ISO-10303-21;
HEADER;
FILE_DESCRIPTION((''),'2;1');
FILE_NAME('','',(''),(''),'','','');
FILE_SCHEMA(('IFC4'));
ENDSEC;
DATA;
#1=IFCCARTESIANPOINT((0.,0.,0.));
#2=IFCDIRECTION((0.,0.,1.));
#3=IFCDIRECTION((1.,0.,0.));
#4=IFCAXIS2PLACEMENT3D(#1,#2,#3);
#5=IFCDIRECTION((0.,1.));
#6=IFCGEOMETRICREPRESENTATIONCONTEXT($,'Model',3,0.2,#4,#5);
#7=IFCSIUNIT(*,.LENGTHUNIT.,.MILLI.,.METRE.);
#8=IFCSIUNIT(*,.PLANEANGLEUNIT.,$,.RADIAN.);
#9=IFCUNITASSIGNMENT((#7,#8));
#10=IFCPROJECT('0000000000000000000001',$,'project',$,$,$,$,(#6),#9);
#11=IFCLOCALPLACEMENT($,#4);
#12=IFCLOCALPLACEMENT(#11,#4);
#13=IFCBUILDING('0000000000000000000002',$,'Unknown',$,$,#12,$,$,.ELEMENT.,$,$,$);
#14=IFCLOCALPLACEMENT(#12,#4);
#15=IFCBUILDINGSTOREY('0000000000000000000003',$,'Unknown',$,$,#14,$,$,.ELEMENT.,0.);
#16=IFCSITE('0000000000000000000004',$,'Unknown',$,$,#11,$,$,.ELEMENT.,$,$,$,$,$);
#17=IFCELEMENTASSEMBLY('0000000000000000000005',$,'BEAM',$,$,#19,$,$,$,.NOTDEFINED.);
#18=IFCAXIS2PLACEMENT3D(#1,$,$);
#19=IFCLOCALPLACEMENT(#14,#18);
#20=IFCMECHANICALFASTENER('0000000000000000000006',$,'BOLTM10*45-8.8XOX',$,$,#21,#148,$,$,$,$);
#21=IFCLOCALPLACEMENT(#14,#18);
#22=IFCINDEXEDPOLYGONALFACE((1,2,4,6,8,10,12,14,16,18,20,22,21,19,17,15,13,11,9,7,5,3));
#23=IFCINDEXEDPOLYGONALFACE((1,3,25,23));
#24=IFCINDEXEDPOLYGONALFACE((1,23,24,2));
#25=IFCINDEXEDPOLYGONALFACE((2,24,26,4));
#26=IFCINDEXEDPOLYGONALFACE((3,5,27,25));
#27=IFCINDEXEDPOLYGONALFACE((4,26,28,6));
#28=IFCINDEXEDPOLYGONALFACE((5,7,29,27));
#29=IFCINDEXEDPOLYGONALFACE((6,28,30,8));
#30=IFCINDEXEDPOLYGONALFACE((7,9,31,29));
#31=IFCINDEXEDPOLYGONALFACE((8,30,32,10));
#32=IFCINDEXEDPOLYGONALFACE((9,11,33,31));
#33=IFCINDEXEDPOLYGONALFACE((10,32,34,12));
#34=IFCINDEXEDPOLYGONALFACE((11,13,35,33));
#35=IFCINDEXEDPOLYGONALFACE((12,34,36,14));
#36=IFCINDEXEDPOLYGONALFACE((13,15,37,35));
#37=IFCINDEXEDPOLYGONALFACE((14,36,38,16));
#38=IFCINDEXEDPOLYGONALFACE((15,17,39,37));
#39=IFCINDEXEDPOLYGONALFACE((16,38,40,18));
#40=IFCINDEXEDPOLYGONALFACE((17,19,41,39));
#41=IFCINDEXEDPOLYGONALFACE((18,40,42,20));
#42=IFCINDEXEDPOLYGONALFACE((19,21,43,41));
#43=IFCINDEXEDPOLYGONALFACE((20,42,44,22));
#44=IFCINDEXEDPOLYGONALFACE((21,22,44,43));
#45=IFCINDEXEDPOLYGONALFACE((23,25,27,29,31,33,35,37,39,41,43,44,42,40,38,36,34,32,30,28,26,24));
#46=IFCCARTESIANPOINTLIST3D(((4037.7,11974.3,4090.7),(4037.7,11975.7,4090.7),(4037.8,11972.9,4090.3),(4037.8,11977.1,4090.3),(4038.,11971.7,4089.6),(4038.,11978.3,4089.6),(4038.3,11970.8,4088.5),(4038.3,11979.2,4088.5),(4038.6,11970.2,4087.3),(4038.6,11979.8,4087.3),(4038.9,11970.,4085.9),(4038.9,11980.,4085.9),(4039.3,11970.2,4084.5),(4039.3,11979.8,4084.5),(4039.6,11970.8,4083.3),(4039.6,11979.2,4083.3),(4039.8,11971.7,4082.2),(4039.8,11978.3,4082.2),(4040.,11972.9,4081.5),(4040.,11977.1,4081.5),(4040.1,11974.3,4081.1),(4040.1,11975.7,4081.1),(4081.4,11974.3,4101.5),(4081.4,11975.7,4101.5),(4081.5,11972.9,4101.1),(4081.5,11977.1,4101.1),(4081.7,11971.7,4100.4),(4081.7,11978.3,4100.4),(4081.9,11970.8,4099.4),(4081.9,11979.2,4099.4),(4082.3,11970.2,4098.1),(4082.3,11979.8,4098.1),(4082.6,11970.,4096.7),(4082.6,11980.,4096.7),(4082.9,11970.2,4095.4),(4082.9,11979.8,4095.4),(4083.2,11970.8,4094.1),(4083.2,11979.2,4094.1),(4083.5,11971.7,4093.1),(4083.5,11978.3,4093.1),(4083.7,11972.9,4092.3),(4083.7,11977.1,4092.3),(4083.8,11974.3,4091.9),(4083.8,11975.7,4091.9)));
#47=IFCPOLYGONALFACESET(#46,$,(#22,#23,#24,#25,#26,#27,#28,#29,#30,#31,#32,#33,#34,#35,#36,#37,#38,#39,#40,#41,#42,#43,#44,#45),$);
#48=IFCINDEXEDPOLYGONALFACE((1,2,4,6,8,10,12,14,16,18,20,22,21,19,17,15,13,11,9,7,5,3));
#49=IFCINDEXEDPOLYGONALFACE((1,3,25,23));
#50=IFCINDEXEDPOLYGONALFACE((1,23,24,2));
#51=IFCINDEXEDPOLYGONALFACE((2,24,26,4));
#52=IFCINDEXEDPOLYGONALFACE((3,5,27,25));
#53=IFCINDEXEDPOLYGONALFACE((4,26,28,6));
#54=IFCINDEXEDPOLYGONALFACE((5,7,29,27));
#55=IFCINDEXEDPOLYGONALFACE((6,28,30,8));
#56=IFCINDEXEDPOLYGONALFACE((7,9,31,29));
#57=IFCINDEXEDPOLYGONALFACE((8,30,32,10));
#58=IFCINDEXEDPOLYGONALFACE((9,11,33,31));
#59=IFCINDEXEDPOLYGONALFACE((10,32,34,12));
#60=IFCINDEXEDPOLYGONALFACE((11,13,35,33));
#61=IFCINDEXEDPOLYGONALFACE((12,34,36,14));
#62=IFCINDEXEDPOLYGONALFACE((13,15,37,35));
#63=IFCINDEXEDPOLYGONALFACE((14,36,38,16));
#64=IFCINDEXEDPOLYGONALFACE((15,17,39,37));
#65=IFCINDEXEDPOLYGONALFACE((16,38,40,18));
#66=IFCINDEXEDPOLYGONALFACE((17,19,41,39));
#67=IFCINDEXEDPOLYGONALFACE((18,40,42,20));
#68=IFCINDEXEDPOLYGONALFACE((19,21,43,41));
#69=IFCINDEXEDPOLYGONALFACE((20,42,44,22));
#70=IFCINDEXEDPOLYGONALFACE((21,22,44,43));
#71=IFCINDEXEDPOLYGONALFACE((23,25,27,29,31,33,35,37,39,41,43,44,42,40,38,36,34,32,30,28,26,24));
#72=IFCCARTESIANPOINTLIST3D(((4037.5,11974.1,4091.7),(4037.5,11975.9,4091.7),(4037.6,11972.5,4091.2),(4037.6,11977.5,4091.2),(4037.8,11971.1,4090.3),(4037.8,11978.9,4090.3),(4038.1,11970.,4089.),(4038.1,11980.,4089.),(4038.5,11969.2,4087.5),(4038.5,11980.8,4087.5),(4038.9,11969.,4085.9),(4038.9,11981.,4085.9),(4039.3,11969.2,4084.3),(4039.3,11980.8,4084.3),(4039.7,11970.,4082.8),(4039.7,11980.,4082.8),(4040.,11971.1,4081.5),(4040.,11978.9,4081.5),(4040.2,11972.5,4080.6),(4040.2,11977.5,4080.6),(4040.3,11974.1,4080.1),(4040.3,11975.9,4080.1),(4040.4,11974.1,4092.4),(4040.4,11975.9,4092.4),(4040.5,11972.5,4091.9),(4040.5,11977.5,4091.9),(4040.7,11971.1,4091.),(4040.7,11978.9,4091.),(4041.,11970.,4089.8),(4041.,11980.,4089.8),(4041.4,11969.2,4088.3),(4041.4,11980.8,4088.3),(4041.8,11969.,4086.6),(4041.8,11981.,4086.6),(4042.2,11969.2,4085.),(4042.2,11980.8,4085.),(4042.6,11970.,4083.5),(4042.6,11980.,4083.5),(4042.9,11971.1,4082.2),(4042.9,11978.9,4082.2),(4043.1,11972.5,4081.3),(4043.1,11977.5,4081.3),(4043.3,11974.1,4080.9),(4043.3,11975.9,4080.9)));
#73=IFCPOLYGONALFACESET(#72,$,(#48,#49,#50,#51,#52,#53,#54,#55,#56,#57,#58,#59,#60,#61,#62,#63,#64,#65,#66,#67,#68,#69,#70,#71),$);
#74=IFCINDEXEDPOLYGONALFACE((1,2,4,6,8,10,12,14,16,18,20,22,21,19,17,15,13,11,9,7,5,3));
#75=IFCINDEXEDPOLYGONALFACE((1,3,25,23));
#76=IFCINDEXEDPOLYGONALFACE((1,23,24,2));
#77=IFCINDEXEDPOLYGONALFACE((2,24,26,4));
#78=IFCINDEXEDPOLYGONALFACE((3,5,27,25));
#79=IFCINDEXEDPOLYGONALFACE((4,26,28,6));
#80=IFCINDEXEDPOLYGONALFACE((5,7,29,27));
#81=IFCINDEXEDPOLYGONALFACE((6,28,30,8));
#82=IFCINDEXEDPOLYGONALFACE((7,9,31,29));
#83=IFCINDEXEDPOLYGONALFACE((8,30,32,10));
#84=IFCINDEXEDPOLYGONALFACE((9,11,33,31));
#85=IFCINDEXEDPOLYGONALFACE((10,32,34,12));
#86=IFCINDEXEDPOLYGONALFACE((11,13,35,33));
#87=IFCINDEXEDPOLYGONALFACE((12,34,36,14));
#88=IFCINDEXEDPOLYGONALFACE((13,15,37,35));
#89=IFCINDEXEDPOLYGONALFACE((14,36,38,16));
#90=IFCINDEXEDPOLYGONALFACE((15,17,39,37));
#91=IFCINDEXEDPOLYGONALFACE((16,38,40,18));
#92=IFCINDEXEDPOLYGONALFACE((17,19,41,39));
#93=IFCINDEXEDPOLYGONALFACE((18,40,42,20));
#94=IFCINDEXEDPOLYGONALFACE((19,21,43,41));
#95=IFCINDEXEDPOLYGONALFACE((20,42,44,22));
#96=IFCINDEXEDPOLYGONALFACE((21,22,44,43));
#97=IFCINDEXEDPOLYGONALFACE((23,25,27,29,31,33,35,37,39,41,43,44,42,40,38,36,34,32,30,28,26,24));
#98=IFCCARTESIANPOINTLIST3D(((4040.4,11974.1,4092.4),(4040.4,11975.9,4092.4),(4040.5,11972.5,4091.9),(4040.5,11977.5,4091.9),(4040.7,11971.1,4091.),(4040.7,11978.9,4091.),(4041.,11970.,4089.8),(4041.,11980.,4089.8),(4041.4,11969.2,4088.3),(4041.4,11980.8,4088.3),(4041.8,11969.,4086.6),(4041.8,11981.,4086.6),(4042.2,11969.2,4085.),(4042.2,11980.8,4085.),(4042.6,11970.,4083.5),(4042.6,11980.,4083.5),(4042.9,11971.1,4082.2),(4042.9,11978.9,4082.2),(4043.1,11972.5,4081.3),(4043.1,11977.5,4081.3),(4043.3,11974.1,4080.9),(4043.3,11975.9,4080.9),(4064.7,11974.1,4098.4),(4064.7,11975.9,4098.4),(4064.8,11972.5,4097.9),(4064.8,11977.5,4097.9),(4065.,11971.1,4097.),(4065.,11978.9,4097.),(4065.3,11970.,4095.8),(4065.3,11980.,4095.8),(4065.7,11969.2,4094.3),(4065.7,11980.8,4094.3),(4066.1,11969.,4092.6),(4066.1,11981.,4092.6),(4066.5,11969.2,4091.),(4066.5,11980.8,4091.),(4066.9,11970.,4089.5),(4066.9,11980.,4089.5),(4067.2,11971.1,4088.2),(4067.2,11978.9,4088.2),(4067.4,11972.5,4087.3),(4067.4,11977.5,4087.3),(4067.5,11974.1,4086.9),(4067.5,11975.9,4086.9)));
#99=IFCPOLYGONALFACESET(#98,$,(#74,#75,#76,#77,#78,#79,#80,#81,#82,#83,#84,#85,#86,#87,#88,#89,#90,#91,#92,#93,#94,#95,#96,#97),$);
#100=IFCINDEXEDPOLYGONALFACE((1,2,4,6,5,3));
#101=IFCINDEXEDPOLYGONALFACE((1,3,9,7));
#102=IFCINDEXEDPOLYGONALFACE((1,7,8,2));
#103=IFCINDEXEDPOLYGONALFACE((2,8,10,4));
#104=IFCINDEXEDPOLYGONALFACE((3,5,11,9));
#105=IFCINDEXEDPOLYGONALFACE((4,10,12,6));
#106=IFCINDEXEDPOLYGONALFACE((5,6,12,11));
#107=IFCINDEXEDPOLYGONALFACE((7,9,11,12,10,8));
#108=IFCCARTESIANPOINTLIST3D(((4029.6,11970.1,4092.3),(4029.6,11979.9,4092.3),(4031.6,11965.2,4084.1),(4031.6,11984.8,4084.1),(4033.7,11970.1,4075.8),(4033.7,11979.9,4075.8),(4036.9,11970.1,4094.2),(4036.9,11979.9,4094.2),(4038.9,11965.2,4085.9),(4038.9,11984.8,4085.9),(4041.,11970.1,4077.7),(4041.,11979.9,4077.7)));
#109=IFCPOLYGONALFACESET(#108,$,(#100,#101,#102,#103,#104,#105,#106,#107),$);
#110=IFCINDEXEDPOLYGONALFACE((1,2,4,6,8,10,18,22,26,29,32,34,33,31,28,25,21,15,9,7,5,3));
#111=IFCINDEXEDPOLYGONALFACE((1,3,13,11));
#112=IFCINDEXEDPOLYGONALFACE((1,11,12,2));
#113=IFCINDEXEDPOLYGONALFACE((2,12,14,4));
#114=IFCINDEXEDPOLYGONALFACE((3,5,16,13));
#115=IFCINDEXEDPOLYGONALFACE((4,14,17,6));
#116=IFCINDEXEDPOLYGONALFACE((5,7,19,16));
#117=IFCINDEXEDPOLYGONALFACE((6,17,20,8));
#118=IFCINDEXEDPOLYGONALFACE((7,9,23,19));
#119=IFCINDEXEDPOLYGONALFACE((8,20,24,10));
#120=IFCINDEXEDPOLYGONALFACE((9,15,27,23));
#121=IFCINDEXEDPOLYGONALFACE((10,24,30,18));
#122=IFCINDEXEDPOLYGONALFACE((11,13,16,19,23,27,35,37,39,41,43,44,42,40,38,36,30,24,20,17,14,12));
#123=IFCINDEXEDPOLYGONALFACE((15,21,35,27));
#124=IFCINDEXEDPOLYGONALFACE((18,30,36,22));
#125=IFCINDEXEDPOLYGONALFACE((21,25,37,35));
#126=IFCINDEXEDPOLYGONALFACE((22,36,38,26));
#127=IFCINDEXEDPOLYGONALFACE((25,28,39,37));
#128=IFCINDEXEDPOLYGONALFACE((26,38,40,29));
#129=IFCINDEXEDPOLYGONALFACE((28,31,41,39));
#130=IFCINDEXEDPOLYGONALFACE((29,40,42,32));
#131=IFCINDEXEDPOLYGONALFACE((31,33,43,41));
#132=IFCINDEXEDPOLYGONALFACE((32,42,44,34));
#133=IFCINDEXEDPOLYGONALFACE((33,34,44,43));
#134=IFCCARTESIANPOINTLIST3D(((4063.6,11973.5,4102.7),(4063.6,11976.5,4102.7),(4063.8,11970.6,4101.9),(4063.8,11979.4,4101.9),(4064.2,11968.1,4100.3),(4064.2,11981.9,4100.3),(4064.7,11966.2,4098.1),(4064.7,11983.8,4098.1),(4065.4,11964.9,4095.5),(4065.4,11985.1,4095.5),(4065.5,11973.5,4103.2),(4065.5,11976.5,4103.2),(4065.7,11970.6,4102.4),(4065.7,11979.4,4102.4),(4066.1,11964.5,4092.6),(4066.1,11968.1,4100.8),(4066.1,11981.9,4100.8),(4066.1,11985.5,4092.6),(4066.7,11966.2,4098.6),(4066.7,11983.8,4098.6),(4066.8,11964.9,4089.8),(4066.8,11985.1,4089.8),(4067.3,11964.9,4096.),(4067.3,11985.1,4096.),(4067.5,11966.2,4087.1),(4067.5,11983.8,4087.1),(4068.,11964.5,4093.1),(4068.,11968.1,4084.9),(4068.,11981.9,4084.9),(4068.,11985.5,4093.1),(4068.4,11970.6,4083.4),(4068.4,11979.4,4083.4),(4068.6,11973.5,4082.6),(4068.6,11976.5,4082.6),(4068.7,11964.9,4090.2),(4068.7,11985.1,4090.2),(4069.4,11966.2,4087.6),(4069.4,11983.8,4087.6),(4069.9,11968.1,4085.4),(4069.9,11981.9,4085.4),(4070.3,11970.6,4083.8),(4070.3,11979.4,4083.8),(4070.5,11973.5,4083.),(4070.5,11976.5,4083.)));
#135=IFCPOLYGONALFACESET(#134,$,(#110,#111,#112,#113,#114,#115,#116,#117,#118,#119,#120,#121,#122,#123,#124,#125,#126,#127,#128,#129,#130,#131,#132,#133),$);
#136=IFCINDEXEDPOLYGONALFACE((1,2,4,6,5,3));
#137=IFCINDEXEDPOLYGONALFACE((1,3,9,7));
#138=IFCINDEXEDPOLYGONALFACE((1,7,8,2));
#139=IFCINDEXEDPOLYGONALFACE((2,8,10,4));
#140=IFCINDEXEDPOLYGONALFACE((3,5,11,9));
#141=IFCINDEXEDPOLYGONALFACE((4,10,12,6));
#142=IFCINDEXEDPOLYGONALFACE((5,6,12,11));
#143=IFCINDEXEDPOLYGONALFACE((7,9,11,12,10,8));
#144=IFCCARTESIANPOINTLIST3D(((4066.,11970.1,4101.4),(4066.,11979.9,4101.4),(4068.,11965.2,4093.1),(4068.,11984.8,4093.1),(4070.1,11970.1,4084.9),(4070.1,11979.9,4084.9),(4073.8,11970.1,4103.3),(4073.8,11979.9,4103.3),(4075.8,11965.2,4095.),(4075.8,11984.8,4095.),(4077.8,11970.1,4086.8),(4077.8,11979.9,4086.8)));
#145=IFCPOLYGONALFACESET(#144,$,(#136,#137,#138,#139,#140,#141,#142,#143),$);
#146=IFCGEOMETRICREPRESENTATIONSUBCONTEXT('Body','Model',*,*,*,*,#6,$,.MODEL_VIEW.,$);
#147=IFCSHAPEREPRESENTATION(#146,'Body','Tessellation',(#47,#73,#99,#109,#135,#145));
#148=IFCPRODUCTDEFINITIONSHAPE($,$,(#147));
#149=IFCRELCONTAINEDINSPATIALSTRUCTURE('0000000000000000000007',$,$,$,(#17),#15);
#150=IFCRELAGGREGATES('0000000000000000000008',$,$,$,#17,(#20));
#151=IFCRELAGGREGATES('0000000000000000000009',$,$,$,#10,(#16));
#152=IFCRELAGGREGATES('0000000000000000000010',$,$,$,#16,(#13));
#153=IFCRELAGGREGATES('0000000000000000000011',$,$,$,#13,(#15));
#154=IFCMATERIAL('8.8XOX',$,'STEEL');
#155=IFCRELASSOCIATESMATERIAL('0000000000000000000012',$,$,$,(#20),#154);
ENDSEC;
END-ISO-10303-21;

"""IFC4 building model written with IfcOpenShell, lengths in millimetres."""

from ifc_helpers import new_model, si_unit, direction, frame, origin_with_axes, place, context, subcontext, project, spatial, line, arc, indexed_curve, outline, extrude, source, transform, mapped, material, element, aggregate, save


model = new_model("IFC4")

# Units and contexts
model_context = context("Model", 3, precision=0.2, world=origin_with_axes(), true_north=direction((0.0, 1.0)))
body_context = subcontext(model_context, "Body", "Model", "MODEL_VIEW")
ifc_project = project(units=[si_unit("LENGTHUNIT", "METRE", prefix="MILLI"), si_unit("PLANEANGLEUNIT", "RADIAN")], contexts=[model_context])

# Site, building, storey
site_placement = place(None, origin_with_axes())
site = spatial("IfcSite", under=ifc_project, at=site_placement, Name="Unknown", CompositionType="ELEMENT")
building_placement = place(site_placement, origin_with_axes())
building = spatial("IfcBuilding", under=site, at=building_placement, Name="Unknown", CompositionType="ELEMENT")
storey_placement = place(building_placement, origin_with_axes())
storey = spatial("IfcBuildingStorey", under=building, at=storey_placement, Name="Unknown", CompositionType="ELEMENT", Elevation=0.0)

# Shared definitions
ifc_material_1 = material(Name="8.8XOX", Category="STEEL")

# Element assembly, mechanical fastener
shared_shape_1 = source(origin_with_axes(), body_context, "Body", "SweptSolid", [
    extrude(outline(indexed_curve([(5.0, 0.0), (0.0, 5.0), (-5.0, 0.0), (0.0, -5.0)], segments=[arc(1, 2, 3), arc(3, 4, 1)])), frame((0.0, 0.0, 3.8), z_axis=(0.0, 0.0, -1.0), x_axis=(0.0, 1.0, 0.0)), (0.0, 0.0, 1.0), 45.0),
    extrude(outline(indexed_curve([(6.0, 0.0), (0.0, 6.0), (-6.0, 0.0), (0.0, -6.0)], segments=[arc(1, 2, 3), arc(3, 4, 1)])), frame((0.0, 0.0, 3.8), z_axis=(0.0, 0.0, -1.0), x_axis=(0.0, 1.0, 0.0)), (0.0, 0.0, 1.0), 3.0),
    extrude(outline(indexed_curve([(6.0, 0.0), (0.0, 6.0), (-6.0, 0.0), (0.0, -6.0)], segments=[arc(1, 2, 3), arc(3, 4, 1)])), frame((0.0, 0.0, 0.8), z_axis=(0.0, 0.0, -1.0), x_axis=(0.0, 1.0, 0.0)), (0.0, 0.0, 1.0), 25.0),
    extrude(outline(indexed_curve([(9.8, 0.0), (4.9, 8.5), (-4.9, 8.5), (-9.8, 0.0), (-4.9, -8.5), (4.9, -8.5)], segments=[line(1, 2, 3, 4, 5, 6, 1)])), frame((0.0, 0.0, 11.2), z_axis=(0.0, 0.0, -1.0), x_axis=(0.0, 1.0, 0.0)), (0.0, 0.0, 1.0), 7.5),
    extrude(outline(indexed_curve([(10.5, 0.0), (0.0, 10.5), (-10.5, 0.0), (0.0, -10.5)], segments=[arc(1, 2, 3), arc(3, 4, 1)])), frame((0.0, 0.0, -24.2), z_axis=(0.0, 0.0, -1.0), x_axis=(0.0, 1.0, 0.0)), (0.0, 0.0, 1.0), 2.0),
    extrude(outline(indexed_curve([(9.8, 0.0), (4.9, 8.5), (-4.9, 8.5), (-9.8, 0.0), (-4.9, -8.5), (4.9, -8.5)], segments=[line(1, 2, 3, 4, 5, 6, 1)])), frame((0.0, 0.0, -26.2), z_axis=(0.0, 0.0, -1.0), x_axis=(0.0, 1.0, 0.0)), (0.0, 0.0, 1.0), 8.0),
])
assembly_1_placement = place(storey_placement, frame((4052.8, 6000.0, 4094.5), z_axis=(0.970613, 0.0, 0.240648), x_axis=(0.0, 1.0, 0.0)))
assembly_1 = element("IfcElementAssembly", 1, at=assembly_1_placement, inside=storey, Name="BEAM", PredefinedType="NOTDEFINED")
mechanical_fastener_1_placement = place(assembly_1_placement, frame((5975.0, -5.0, -11.8), z_axis=(0.0, 0.0, -1.0), x_axis=(0.0, 1.0, 0.0)))
mechanical_fastener_1 = element("IfcMechanicalFastener", 2, at=mechanical_fastener_1_placement, material=ifc_material_1, Name="BOLTM10*45-8.8XOX", context=body_context, shape_type="MappedRepresentation", body=[
    mapped(shared_shape_1, transform((0.0, 0.0, 0.0))),
])
aggregate(assembly_1, [mechanical_fastener_1])

save(model, "model.ifc")
